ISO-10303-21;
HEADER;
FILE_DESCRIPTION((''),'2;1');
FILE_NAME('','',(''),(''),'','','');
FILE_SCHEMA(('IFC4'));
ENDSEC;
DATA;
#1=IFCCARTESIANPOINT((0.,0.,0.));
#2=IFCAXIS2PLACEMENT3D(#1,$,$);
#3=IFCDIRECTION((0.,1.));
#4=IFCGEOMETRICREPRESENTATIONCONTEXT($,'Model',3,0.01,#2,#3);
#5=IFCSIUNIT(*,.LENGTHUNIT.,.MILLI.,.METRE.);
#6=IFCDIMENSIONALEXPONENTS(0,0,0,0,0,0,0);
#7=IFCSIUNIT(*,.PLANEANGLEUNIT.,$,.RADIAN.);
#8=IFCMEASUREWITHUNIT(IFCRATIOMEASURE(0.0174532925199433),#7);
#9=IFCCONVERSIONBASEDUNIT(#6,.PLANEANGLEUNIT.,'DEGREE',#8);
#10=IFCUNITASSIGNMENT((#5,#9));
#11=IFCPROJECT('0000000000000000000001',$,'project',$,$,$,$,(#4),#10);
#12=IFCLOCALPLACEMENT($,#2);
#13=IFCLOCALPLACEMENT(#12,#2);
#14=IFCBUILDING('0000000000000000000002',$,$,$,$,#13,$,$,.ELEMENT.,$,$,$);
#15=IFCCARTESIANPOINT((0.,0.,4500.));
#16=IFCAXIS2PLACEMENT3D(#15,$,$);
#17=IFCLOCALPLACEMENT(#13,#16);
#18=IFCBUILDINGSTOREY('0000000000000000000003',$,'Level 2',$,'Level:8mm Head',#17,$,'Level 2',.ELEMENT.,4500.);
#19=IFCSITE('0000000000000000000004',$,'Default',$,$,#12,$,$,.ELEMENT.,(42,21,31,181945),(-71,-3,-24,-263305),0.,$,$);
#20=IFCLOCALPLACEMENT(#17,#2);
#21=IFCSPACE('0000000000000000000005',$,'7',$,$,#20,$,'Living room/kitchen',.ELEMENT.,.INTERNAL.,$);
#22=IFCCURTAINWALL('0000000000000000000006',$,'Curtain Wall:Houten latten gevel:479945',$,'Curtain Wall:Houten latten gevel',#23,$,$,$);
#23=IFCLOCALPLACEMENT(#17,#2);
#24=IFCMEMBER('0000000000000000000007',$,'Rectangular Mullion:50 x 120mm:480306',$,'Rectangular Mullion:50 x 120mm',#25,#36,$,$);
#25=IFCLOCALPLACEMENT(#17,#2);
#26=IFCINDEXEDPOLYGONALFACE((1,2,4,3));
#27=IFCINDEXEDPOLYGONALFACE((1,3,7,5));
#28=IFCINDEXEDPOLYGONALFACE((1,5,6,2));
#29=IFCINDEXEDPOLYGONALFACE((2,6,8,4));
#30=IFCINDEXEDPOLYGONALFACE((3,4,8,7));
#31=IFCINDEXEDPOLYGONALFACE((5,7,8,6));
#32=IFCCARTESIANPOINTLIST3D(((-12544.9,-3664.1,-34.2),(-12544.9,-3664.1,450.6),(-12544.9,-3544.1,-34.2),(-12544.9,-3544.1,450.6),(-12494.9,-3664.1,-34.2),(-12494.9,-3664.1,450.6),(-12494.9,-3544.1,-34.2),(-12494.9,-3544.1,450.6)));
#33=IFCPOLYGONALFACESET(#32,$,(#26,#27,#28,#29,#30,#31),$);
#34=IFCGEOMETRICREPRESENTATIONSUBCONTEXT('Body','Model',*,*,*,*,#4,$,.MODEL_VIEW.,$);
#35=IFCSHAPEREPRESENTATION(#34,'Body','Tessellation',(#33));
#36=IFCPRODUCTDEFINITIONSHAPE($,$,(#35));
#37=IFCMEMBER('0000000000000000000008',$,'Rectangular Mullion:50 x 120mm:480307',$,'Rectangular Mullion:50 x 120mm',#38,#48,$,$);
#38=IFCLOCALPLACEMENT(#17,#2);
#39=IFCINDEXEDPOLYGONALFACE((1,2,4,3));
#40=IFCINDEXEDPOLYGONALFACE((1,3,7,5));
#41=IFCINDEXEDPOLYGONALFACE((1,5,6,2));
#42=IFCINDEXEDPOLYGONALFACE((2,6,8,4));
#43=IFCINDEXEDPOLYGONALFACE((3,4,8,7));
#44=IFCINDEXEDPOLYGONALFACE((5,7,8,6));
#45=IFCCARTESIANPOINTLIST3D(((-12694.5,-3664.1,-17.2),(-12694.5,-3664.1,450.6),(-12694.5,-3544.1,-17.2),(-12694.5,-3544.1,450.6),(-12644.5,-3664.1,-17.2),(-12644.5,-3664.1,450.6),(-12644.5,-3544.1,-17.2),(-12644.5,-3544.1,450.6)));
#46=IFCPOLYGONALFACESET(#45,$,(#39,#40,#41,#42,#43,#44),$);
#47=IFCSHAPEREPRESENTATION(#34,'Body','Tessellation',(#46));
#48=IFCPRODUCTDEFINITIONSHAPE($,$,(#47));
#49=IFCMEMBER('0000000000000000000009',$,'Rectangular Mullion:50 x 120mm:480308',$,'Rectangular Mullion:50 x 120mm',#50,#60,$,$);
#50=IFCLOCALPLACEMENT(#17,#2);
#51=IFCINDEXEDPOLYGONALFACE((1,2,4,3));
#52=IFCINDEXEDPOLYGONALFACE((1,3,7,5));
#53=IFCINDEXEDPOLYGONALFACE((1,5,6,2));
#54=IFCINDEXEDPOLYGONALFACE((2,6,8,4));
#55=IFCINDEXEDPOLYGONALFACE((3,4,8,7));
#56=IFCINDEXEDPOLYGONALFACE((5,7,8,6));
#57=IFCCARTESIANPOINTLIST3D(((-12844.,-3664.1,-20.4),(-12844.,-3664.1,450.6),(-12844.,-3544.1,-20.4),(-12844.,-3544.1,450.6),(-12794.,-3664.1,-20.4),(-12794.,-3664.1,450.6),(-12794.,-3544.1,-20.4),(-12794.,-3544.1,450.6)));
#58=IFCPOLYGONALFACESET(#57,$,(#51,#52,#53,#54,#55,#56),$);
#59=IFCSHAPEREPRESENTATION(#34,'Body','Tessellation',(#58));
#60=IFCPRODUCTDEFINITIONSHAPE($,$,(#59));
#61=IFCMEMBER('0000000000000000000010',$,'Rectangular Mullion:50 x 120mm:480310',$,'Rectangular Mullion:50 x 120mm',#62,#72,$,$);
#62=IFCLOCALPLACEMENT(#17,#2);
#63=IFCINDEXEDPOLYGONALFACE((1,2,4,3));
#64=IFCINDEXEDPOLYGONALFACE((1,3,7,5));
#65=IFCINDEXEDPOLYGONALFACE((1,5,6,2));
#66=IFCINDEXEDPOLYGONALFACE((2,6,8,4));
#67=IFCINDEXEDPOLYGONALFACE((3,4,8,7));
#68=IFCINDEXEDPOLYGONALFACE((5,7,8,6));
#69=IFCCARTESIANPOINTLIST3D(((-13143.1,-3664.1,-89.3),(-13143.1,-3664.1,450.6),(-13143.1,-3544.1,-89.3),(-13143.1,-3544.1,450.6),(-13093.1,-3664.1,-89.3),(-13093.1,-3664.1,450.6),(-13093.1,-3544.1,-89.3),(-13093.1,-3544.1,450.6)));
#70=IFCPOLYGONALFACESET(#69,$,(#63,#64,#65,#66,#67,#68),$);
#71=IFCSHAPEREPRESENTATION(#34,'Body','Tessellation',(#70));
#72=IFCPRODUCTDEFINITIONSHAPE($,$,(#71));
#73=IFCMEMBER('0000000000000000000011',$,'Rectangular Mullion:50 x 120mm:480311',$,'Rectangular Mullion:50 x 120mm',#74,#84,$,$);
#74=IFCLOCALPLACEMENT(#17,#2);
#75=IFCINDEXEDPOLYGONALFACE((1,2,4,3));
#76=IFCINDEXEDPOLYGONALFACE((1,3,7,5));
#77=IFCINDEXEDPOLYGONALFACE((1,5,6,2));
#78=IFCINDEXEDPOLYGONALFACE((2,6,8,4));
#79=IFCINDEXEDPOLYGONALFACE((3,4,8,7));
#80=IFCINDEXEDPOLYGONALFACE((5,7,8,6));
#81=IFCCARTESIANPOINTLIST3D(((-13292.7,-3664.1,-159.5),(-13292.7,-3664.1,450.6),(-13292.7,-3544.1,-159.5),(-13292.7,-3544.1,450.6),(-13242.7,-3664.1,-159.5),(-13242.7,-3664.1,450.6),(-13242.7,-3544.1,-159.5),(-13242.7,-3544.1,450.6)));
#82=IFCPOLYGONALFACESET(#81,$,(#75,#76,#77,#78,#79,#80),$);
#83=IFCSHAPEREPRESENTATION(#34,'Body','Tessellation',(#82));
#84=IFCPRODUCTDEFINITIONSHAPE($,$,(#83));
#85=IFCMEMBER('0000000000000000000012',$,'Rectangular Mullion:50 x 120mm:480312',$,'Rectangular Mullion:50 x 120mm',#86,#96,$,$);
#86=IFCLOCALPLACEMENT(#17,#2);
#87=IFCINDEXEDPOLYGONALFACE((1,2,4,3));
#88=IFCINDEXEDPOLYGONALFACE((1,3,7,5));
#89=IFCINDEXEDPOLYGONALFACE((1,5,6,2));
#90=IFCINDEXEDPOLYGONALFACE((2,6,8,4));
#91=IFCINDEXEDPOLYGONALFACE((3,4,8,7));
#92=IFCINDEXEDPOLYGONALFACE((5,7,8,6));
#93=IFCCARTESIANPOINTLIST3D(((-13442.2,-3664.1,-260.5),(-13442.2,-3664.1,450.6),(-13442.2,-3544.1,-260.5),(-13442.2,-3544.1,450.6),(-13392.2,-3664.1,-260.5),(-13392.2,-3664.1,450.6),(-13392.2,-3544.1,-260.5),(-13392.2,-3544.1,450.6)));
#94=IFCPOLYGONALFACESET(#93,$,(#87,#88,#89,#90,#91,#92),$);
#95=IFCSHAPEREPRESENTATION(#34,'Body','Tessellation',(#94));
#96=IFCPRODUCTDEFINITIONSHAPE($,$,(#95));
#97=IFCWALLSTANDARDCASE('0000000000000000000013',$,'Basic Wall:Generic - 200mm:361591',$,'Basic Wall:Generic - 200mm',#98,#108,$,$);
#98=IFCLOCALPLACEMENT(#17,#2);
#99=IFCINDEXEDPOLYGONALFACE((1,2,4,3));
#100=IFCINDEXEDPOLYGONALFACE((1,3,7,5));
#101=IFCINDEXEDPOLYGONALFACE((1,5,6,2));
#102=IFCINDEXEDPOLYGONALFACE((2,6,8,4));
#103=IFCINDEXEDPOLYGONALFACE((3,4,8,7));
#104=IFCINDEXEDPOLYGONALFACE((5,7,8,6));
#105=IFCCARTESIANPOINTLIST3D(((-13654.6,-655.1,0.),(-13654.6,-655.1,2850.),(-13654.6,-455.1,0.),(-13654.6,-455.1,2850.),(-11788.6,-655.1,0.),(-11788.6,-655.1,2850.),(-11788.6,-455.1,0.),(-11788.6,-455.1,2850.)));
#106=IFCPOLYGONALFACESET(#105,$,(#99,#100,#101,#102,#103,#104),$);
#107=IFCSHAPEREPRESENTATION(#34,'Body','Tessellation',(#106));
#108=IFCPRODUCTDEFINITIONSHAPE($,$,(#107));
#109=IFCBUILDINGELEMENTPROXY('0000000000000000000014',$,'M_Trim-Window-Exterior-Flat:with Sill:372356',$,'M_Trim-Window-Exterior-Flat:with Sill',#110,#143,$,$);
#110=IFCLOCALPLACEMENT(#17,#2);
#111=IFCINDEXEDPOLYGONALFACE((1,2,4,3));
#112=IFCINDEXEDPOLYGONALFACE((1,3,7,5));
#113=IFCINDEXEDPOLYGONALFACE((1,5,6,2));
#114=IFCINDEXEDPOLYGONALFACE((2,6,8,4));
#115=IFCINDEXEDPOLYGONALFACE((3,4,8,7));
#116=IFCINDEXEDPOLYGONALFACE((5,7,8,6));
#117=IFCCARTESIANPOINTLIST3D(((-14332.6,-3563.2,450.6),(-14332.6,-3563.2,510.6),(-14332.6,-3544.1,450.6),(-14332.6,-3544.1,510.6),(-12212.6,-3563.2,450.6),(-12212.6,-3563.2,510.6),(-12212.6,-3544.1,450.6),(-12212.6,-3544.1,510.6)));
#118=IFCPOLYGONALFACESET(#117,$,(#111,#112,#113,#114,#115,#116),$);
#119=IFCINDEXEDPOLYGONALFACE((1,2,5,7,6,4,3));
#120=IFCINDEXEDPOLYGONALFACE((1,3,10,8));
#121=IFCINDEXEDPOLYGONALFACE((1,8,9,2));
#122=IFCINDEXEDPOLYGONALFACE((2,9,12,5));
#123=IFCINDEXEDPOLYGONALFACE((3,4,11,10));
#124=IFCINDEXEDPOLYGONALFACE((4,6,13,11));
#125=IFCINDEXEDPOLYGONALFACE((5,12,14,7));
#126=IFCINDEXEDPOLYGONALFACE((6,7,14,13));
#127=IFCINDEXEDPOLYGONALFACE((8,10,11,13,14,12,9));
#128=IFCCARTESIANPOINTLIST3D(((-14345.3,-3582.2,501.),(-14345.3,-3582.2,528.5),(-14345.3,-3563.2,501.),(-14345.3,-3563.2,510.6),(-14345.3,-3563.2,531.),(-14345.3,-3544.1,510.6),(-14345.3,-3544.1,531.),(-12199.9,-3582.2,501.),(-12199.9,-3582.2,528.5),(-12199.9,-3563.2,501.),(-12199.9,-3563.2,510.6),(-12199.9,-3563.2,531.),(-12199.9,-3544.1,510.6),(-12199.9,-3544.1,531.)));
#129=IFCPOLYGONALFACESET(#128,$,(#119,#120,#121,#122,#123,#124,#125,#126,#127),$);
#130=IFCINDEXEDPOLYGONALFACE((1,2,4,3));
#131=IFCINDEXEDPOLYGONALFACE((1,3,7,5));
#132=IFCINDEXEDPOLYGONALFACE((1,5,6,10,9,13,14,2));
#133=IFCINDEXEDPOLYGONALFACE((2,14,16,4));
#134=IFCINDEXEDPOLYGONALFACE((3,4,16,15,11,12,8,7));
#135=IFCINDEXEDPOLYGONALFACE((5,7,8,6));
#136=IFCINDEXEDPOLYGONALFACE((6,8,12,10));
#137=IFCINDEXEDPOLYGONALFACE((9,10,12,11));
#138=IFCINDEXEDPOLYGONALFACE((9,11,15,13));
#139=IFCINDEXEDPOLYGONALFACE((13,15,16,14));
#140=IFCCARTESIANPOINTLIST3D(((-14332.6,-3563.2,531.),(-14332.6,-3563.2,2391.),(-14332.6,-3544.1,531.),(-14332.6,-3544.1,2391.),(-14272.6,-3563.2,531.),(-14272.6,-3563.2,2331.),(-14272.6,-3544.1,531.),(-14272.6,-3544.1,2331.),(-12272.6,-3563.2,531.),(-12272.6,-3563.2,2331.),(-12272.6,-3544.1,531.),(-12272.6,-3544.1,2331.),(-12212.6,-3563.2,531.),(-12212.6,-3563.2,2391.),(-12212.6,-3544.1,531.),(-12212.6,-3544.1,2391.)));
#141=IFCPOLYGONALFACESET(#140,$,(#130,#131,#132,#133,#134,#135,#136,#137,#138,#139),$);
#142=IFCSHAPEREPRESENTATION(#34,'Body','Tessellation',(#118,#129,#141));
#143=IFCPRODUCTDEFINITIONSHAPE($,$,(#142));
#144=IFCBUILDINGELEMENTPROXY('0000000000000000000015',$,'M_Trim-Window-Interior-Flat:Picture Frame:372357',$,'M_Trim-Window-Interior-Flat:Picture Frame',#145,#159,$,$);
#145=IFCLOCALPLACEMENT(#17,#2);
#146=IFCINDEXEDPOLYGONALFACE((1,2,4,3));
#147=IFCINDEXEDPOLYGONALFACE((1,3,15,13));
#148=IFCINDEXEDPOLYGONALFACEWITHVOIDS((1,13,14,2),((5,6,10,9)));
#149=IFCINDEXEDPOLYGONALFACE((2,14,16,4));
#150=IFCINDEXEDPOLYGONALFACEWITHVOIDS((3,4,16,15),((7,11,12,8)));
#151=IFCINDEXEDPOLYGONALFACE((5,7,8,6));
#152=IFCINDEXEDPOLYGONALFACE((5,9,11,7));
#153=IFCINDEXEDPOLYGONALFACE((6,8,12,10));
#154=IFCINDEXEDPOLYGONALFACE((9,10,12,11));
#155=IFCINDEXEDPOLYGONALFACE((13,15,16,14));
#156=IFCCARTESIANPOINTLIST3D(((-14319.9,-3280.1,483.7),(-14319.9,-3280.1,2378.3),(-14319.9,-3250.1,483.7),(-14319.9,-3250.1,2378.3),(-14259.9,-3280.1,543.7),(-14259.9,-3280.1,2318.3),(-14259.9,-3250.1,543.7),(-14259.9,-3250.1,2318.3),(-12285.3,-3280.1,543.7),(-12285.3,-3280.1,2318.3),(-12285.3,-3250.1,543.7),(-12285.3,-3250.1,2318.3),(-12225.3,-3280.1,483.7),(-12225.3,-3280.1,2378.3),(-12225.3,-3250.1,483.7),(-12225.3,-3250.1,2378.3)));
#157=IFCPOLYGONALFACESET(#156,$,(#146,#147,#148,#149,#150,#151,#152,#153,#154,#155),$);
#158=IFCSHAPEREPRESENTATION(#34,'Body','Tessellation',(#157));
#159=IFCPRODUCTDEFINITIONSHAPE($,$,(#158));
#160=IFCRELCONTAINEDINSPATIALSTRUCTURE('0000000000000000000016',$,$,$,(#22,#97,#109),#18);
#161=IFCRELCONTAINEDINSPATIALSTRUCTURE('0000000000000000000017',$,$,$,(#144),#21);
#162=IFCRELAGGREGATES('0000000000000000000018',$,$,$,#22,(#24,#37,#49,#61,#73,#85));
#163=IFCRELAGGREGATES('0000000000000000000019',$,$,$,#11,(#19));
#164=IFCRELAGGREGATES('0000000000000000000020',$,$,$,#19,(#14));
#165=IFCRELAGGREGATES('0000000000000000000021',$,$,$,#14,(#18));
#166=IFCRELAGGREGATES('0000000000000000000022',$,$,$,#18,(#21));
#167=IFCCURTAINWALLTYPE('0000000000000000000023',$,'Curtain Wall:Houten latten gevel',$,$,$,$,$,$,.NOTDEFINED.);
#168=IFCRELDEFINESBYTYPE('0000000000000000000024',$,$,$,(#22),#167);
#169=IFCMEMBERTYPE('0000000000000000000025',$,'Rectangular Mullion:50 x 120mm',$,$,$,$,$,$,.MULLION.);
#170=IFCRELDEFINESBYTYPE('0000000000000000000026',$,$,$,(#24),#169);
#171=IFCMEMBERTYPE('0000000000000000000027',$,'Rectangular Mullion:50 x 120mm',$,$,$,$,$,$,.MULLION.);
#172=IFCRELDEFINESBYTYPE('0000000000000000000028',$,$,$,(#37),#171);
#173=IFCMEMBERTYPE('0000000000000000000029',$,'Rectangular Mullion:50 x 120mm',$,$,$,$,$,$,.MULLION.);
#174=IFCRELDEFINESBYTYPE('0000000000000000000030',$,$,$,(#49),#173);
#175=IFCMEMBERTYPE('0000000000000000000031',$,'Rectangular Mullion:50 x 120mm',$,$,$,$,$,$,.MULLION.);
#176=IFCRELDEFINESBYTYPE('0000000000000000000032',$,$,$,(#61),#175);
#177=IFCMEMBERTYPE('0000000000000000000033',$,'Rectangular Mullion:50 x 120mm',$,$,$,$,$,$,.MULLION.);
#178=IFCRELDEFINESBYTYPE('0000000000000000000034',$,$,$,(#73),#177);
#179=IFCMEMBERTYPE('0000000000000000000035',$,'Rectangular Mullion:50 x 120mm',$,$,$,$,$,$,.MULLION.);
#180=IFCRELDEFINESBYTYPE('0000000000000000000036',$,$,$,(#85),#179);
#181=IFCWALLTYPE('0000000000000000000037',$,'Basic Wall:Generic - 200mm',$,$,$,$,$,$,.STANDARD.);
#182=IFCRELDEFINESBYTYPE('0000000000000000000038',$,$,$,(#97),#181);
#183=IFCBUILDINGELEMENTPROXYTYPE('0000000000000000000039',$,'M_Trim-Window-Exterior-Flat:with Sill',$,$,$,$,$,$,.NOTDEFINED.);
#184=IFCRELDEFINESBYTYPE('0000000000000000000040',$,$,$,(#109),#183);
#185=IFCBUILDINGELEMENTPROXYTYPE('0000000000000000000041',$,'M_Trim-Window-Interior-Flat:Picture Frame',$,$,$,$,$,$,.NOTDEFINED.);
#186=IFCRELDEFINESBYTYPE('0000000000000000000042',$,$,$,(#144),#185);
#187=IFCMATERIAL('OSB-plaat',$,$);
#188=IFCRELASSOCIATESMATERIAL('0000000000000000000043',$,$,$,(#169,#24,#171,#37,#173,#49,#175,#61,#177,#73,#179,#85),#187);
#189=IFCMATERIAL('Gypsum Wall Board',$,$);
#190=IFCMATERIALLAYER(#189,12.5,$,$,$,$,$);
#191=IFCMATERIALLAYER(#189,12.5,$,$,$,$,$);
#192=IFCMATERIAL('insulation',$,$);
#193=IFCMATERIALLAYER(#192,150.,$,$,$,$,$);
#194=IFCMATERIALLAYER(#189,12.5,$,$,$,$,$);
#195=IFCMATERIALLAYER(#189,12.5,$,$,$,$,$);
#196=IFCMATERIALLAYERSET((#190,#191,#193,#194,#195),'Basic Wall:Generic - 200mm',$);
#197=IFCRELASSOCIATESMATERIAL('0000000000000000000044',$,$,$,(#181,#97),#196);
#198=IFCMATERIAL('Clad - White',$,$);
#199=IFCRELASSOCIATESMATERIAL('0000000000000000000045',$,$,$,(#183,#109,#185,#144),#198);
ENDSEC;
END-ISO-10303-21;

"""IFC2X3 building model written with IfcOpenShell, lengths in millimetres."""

from ifc_helpers import new_model, entity, si_unit, converted_unit, direction, frame, frame_2d, origin, origin_2d_with_axis, place, context, subcontext, project, spatial, polyline, rectangle, outline, extrude, source, transform, mapped, material, layer, layer_set, layer_usage, type_object, type_shapes, element, aggregate, save


model = new_model("IFC2X3")

# Units and contexts
model_context = context("Model", 3, precision=0.01, world=origin(), true_north=direction((0.0, 1.0)))
body_context = subcontext(model_context, "Body", "Model", "MODEL_VIEW")
ifc_project = project(units=[si_unit("LENGTHUNIT", "METRE", prefix="MILLI"), converted_unit("PLANEANGLEUNIT", "DEGREE", entity("IfcRatioMeasure", 0.0174532925199433), si_unit("PLANEANGLEUNIT", "RADIAN"), dimensions=[0, 0, 0, 0, 0, 0, 0])], contexts=[model_context])

# Site, building, storey
site_placement = place(None, frame((0.0, 0.0, 0.0)))
site = spatial("IfcSite", under=ifc_project, at=site_placement, Name="Default", CompositionType="ELEMENT", RefLatitude=(42, 21, 31, 181945), RefLongitude=(-71, -3, -24, -263305), RefElevation=0.0)
building_placement = place(site_placement, origin())
building = spatial("IfcBuilding", under=site, at=building_placement, CompositionType="ELEMENT")
storey_placement = place(building_placement, frame((0.0, 0.0, 4500.0)))
storey = spatial("IfcBuildingStorey", under=building, at=storey_placement, Name="Level 2", ObjectType="Level:8mm Head", LongName="Level 2", CompositionType="ELEMENT", Elevation=4500.0)

# Curtain wall, members
curtain_wall_type = type_object("IfcCurtainWallType", Name="Curtain Wall:Houten latten gevel", PredefinedType="NOTDEFINED")
curtain_wall_placement = place(storey_placement, frame((0.0, 0.0, -4500.0)))
curtain_wall = element("IfcCurtainWall", 1, at=curtain_wall_placement, inside=storey, type_object=curtain_wall_type, Name="Curtain Wall:Houten latten gevel:479945", ObjectType="Curtain Wall:Houten latten gevel")
ifc_material_1 = material(Name="OSB-plaat")
member_type_1 = type_object("IfcMemberType", Name="Rectangular Mullion:50 x 120mm", PredefinedType="MULLION", material=ifc_material_1)
shared_shape_1 = source(origin(), body_context, "Body", "SweptSolid", [
    extrude(rectangle(XDim=120.0, YDim=50.0, at=origin_2d_with_axis()), frame((0.0, 0.0, -484.8), z_axis=(0.0, 0.0, 1.0), x_axis=(0.0, -1.0, 0.0)), (0.0, 0.0, 1.0), 484.8),
])
type_shapes(member_type_1, [shared_shape_1])
member_1_placement = place(storey_placement, frame((-12519.9, -3604.1, -34.2), z_axis=(0.0, 0.0, -1.0), x_axis=(-1.0, 0.0, 0.0)))
member_1 = element("IfcMember", 2, at=member_1_placement, type_object=member_type_1, material=ifc_material_1, Name="Rectangular Mullion:50 x 120mm:480306", ObjectType="Rectangular Mullion:50 x 120mm", context=body_context, shape_type="MappedRepresentation", body=[
    mapped(shared_shape_1, transform((0.0, 0.0, 0.0), scale=1.0)),
])
member_type_2 = type_object("IfcMemberType", Name="Rectangular Mullion:50 x 120mm", PredefinedType="MULLION", material=ifc_material_1)
shared_shape_2 = source(origin(), body_context, "Body", "SweptSolid", [
    extrude(rectangle(XDim=120.0, YDim=50.0, at=origin_2d_with_axis()), frame((0.0, 0.0, -467.7), z_axis=(0.0, 0.0, 1.0), x_axis=(0.0, -1.0, 0.0)), (0.0, 0.0, 1.0), 467.7),
])
type_shapes(member_type_2, [shared_shape_2])
member_2_placement = place(storey_placement, frame((-12669.5, -3604.1, -17.2), z_axis=(0.0, 0.0, -1.0), x_axis=(-1.0, 0.0, 0.0)))
member_2 = element("IfcMember", 3, at=member_2_placement, type_object=member_type_2, material=ifc_material_1, Name="Rectangular Mullion:50 x 120mm:480307", ObjectType="Rectangular Mullion:50 x 120mm", context=body_context, shape_type="MappedRepresentation", body=[
    mapped(shared_shape_2, transform((0.0, 0.0, 0.0), scale=1.0)),
])
member_type_3 = type_object("IfcMemberType", Name="Rectangular Mullion:50 x 120mm", PredefinedType="MULLION", material=ifc_material_1)
shared_shape_3 = source(origin(), body_context, "Body", "SweptSolid", [
    extrude(rectangle(XDim=120.0, YDim=50.0, at=origin_2d_with_axis()), frame((0.0, 0.0, -470.9), z_axis=(0.0, 0.0, 1.0), x_axis=(0.0, -1.0, 0.0)), (0.0, 0.0, 1.0), 470.9),
])
type_shapes(member_type_3, [shared_shape_3])
member_3_placement = place(storey_placement, frame((-12819.0, -3604.1, -20.4), z_axis=(0.0, 0.0, -1.0), x_axis=(-1.0, 0.0, 0.0)))
member_3 = element("IfcMember", 4, at=member_3_placement, type_object=member_type_3, material=ifc_material_1, Name="Rectangular Mullion:50 x 120mm:480308", ObjectType="Rectangular Mullion:50 x 120mm", context=body_context, shape_type="MappedRepresentation", body=[
    mapped(shared_shape_3, transform((0.0, 0.0, 0.0), scale=1.0)),
])
member_type_4 = type_object("IfcMemberType", Name="Rectangular Mullion:50 x 120mm", PredefinedType="MULLION", material=ifc_material_1)
shared_shape_4 = source(origin(), body_context, "Body", "SweptSolid", [
    extrude(rectangle(XDim=120.0, YDim=50.0, at=origin_2d_with_axis()), frame((0.0, 0.0, -539.9), z_axis=(0.0, 0.0, 1.0), x_axis=(0.0, -1.0, 0.0)), (0.0, 0.0, 1.0), 539.9),
])
type_shapes(member_type_4, [shared_shape_4])
member_4_placement = place(storey_placement, frame((-13118.1, -3604.1, -89.3), z_axis=(0.0, 0.0, -1.0), x_axis=(-1.0, 0.0, 0.0)))
member_4 = element("IfcMember", 5, at=member_4_placement, type_object=member_type_4, material=ifc_material_1, Name="Rectangular Mullion:50 x 120mm:480310", ObjectType="Rectangular Mullion:50 x 120mm", context=body_context, shape_type="MappedRepresentation", body=[
    mapped(shared_shape_4, transform((0.0, 0.0, 0.0), scale=1.0)),
])
member_type_5 = type_object("IfcMemberType", Name="Rectangular Mullion:50 x 120mm", PredefinedType="MULLION", material=ifc_material_1)
shared_shape_5 = source(origin(), body_context, "Body", "SweptSolid", [
    extrude(rectangle(XDim=120.0, YDim=50.0, at=origin_2d_with_axis()), frame((0.0, 0.0, -610.1), z_axis=(0.0, 0.0, 1.0), x_axis=(0.0, -1.0, 0.0)), (0.0, 0.0, 1.0), 610.1),
])
type_shapes(member_type_5, [shared_shape_5])
member_5_placement = place(storey_placement, frame((-13267.7, -3604.1, -159.5), z_axis=(0.0, 0.0, -1.0), x_axis=(-1.0, 0.0, 0.0)))
member_5 = element("IfcMember", 6, at=member_5_placement, type_object=member_type_5, material=ifc_material_1, Name="Rectangular Mullion:50 x 120mm:480311", ObjectType="Rectangular Mullion:50 x 120mm", context=body_context, shape_type="MappedRepresentation", body=[
    mapped(shared_shape_5, transform((0.0, 0.0, 0.0), scale=1.0)),
])
member_type_6 = type_object("IfcMemberType", Name="Rectangular Mullion:50 x 120mm", PredefinedType="MULLION", material=ifc_material_1)
shared_shape_6 = source(origin(), body_context, "Body", "SweptSolid", [
    extrude(rectangle(XDim=120.0, YDim=50.0, at=origin_2d_with_axis()), frame((0.0, 0.0, -711.0), z_axis=(0.0, 0.0, 1.0), x_axis=(0.0, -1.0, 0.0)), (0.0, 0.0, 1.0), 711.0),
])
type_shapes(member_type_6, [shared_shape_6])
member_6_placement = place(storey_placement, frame((-13417.2, -3604.1, -260.5), z_axis=(0.0, 0.0, -1.0), x_axis=(-1.0, 0.0, 0.0)))
member_6 = element("IfcMember", 7, at=member_6_placement, type_object=member_type_6, material=ifc_material_1, Name="Rectangular Mullion:50 x 120mm:480312", ObjectType="Rectangular Mullion:50 x 120mm", context=body_context, shape_type="MappedRepresentation", body=[
    mapped(shared_shape_6, transform((0.0, 0.0, 0.0), scale=1.0)),
])
aggregate(curtain_wall, [member_1, member_2, member_3, member_4, member_5, member_6])

# Shared definitions
ifc_material_2 = material(Name="Gypsum Wall Board")
ifc_layer_1 = layer(ifc_material_2, 12.5)
ifc_layer_2 = layer(ifc_material_2, 12.5)
ifc_material_3 = material(Name="insulation")
ifc_layer_3 = layer(ifc_material_3, 150.0)
ifc_layer_4 = layer(ifc_material_2, 12.5)
ifc_layer_5 = layer(ifc_material_2, 12.5)
ifc_layer_set = layer_set([ifc_layer_1, ifc_layer_2, ifc_layer_3, ifc_layer_4, ifc_layer_5], Name="Basic Wall:Generic - 200mm")
wall_type = type_object("IfcWallType", Name="Basic Wall:Generic - 200mm", PredefinedType="STANDARD", material=ifc_layer_set)
ifc_material_4 = material(Name="Clad - White")

# Wall
ifc_layer_usage_1 = layer_usage(ifc_layer_set, "AXIS2", "NEGATIVE", 100.0)
wall_1_placement = place(storey_placement, frame((-13654.6, -555.1, 0.0)))
element("IfcWallStandardCase", 8, at=wall_1_placement, inside=storey, type_object=wall_type, material=ifc_layer_usage_1, Name="Basic Wall:Generic - 200mm:361591", ObjectType="Basic Wall:Generic - 200mm", context=body_context, shape_type="SweptSolid", body=[
    extrude(rectangle(XDim=1866.0, YDim=200.0, at=frame_2d((933.0, 0.0), x_axis=(-1.0, 0.0))), origin(), (0.0, 0.0, 1.0), 2850.0),
])

# Building element proxy
building_element_proxy_type_1 = type_object("IfcBuildingElementProxyType", Name="M_Trim-Window-Exterior-Flat:with Sill", PredefinedType="NOTDEFINED", material=ifc_material_4)
shared_shape_7 = source(origin(), body_context, "Body", "SweptSolid", [
    extrude(rectangle(XDim=2120.0, YDim=60.0, at=frame_2d((0.0, 0.0), x_axis=(1.0, 0.0))), frame((0.0, -1850.4, 0.0), z_axis=(0.0, 0.0, 1.0), x_axis=(-1.0, 0.0, 0.0)), (0.0, 0.0, 1.0), 19.1),
    extrude(outline(polyline([(-19.0, -15.2), (0.0, -15.2), (0.0, -5.7), (19.0, -5.7), (19.0, 14.8), (0.0, 14.8), (-19.0, 12.3), (-19.0, -15.2)])), frame((-1072.7, -1814.8, 19.0), z_axis=(1.0, 0.0, 0.0), x_axis=(0.0, 0.0, -1.0)), (0.0, 0.0, 1.0), 2145.4),
    extrude(outline(polyline([(-945.0, -1060.0), (915.0, -1060.0), (915.0, -1000.0), (-885.0, -1000.0), (-885.0, 1000.0), (915.0, 1000.0), (915.0, 1060.0), (-945.0, 1060.0), (-945.0, -1060.0)])), frame((0.0, -885.0, 0.0), z_axis=(0.0, 0.0, 1.0), x_axis=(0.0, -1.0, 0.0)), (0.0, 0.0, 1.0), 19.1),
])
type_shapes(building_element_proxy_type_1, [shared_shape_7])
proxy_1_placement = place(storey_placement, frame((-13272.6, -3544.1, 2331.0), z_axis=(0.0, -1.0, 0.0), x_axis=(1.0, 0.0, 0.0)))
element("IfcBuildingElementProxy", 9, at=proxy_1_placement, inside=storey, type_object=building_element_proxy_type_1, material=ifc_material_4, Name="M_Trim-Window-Exterior-Flat:with Sill:372356", ObjectType="M_Trim-Window-Exterior-Flat:with Sill", context=body_context, shape_type="MappedRepresentation", body=[
    mapped(shared_shape_7, transform((0.0, 0.0, 0.0), scale=1.0)),
])

# Shared definitions
space_placement = place(storey_placement, origin())
space = spatial("IfcSpace", under=storey, at=space_placement, Name="7", LongName="Living room/kitchen", CompositionType="ELEMENT", InteriorOrExteriorSpace="INTERNAL")

# Building element proxy
building_element_proxy_type_2 = type_object("IfcBuildingElementProxyType", Name="M_Trim-Window-Interior-Flat:Picture Frame", PredefinedType="NOTDEFINED", material=ifc_material_4)
shared_shape_8 = source(origin(), body_context, "Body", "SweptSolid", [
    extrude(outline(polyline([(-1047.3, -947.3), (1047.3, -947.3), (1047.3, 947.3), (-1047.3, 947.3), (-1047.3, -947.3)]), holes=[polyline([(-987.3, -887.3), (-987.3, 887.3), (987.3, 887.3), (987.3, -887.3), (-987.3, -887.3)])]), frame((0.0, -900.0, 0.0), z_axis=(0.0, 0.0, 1.0), x_axis=(-1.0, 0.0, 0.0)), (0.0, 0.0, 1.0), 30.0),
])
type_shapes(building_element_proxy_type_2, [shared_shape_8])
proxy_2_placement = place(space_placement, frame((-13272.6, -3280.1, 2331.0), z_axis=(0.0, 1.0, 0.0), x_axis=(-1.0, 0.0, 0.0)))
element("IfcBuildingElementProxy", 10, at=proxy_2_placement, inside=space, type_object=building_element_proxy_type_2, material=ifc_material_4, Name="M_Trim-Window-Interior-Flat:Picture Frame:372357", ObjectType="M_Trim-Window-Interior-Flat:Picture Frame", context=body_context, shape_type="MappedRepresentation", body=[
    mapped(shared_shape_8, transform((0.0, 0.0, 0.0), scale=1.0)),
])

save(model, "model.ifc")
